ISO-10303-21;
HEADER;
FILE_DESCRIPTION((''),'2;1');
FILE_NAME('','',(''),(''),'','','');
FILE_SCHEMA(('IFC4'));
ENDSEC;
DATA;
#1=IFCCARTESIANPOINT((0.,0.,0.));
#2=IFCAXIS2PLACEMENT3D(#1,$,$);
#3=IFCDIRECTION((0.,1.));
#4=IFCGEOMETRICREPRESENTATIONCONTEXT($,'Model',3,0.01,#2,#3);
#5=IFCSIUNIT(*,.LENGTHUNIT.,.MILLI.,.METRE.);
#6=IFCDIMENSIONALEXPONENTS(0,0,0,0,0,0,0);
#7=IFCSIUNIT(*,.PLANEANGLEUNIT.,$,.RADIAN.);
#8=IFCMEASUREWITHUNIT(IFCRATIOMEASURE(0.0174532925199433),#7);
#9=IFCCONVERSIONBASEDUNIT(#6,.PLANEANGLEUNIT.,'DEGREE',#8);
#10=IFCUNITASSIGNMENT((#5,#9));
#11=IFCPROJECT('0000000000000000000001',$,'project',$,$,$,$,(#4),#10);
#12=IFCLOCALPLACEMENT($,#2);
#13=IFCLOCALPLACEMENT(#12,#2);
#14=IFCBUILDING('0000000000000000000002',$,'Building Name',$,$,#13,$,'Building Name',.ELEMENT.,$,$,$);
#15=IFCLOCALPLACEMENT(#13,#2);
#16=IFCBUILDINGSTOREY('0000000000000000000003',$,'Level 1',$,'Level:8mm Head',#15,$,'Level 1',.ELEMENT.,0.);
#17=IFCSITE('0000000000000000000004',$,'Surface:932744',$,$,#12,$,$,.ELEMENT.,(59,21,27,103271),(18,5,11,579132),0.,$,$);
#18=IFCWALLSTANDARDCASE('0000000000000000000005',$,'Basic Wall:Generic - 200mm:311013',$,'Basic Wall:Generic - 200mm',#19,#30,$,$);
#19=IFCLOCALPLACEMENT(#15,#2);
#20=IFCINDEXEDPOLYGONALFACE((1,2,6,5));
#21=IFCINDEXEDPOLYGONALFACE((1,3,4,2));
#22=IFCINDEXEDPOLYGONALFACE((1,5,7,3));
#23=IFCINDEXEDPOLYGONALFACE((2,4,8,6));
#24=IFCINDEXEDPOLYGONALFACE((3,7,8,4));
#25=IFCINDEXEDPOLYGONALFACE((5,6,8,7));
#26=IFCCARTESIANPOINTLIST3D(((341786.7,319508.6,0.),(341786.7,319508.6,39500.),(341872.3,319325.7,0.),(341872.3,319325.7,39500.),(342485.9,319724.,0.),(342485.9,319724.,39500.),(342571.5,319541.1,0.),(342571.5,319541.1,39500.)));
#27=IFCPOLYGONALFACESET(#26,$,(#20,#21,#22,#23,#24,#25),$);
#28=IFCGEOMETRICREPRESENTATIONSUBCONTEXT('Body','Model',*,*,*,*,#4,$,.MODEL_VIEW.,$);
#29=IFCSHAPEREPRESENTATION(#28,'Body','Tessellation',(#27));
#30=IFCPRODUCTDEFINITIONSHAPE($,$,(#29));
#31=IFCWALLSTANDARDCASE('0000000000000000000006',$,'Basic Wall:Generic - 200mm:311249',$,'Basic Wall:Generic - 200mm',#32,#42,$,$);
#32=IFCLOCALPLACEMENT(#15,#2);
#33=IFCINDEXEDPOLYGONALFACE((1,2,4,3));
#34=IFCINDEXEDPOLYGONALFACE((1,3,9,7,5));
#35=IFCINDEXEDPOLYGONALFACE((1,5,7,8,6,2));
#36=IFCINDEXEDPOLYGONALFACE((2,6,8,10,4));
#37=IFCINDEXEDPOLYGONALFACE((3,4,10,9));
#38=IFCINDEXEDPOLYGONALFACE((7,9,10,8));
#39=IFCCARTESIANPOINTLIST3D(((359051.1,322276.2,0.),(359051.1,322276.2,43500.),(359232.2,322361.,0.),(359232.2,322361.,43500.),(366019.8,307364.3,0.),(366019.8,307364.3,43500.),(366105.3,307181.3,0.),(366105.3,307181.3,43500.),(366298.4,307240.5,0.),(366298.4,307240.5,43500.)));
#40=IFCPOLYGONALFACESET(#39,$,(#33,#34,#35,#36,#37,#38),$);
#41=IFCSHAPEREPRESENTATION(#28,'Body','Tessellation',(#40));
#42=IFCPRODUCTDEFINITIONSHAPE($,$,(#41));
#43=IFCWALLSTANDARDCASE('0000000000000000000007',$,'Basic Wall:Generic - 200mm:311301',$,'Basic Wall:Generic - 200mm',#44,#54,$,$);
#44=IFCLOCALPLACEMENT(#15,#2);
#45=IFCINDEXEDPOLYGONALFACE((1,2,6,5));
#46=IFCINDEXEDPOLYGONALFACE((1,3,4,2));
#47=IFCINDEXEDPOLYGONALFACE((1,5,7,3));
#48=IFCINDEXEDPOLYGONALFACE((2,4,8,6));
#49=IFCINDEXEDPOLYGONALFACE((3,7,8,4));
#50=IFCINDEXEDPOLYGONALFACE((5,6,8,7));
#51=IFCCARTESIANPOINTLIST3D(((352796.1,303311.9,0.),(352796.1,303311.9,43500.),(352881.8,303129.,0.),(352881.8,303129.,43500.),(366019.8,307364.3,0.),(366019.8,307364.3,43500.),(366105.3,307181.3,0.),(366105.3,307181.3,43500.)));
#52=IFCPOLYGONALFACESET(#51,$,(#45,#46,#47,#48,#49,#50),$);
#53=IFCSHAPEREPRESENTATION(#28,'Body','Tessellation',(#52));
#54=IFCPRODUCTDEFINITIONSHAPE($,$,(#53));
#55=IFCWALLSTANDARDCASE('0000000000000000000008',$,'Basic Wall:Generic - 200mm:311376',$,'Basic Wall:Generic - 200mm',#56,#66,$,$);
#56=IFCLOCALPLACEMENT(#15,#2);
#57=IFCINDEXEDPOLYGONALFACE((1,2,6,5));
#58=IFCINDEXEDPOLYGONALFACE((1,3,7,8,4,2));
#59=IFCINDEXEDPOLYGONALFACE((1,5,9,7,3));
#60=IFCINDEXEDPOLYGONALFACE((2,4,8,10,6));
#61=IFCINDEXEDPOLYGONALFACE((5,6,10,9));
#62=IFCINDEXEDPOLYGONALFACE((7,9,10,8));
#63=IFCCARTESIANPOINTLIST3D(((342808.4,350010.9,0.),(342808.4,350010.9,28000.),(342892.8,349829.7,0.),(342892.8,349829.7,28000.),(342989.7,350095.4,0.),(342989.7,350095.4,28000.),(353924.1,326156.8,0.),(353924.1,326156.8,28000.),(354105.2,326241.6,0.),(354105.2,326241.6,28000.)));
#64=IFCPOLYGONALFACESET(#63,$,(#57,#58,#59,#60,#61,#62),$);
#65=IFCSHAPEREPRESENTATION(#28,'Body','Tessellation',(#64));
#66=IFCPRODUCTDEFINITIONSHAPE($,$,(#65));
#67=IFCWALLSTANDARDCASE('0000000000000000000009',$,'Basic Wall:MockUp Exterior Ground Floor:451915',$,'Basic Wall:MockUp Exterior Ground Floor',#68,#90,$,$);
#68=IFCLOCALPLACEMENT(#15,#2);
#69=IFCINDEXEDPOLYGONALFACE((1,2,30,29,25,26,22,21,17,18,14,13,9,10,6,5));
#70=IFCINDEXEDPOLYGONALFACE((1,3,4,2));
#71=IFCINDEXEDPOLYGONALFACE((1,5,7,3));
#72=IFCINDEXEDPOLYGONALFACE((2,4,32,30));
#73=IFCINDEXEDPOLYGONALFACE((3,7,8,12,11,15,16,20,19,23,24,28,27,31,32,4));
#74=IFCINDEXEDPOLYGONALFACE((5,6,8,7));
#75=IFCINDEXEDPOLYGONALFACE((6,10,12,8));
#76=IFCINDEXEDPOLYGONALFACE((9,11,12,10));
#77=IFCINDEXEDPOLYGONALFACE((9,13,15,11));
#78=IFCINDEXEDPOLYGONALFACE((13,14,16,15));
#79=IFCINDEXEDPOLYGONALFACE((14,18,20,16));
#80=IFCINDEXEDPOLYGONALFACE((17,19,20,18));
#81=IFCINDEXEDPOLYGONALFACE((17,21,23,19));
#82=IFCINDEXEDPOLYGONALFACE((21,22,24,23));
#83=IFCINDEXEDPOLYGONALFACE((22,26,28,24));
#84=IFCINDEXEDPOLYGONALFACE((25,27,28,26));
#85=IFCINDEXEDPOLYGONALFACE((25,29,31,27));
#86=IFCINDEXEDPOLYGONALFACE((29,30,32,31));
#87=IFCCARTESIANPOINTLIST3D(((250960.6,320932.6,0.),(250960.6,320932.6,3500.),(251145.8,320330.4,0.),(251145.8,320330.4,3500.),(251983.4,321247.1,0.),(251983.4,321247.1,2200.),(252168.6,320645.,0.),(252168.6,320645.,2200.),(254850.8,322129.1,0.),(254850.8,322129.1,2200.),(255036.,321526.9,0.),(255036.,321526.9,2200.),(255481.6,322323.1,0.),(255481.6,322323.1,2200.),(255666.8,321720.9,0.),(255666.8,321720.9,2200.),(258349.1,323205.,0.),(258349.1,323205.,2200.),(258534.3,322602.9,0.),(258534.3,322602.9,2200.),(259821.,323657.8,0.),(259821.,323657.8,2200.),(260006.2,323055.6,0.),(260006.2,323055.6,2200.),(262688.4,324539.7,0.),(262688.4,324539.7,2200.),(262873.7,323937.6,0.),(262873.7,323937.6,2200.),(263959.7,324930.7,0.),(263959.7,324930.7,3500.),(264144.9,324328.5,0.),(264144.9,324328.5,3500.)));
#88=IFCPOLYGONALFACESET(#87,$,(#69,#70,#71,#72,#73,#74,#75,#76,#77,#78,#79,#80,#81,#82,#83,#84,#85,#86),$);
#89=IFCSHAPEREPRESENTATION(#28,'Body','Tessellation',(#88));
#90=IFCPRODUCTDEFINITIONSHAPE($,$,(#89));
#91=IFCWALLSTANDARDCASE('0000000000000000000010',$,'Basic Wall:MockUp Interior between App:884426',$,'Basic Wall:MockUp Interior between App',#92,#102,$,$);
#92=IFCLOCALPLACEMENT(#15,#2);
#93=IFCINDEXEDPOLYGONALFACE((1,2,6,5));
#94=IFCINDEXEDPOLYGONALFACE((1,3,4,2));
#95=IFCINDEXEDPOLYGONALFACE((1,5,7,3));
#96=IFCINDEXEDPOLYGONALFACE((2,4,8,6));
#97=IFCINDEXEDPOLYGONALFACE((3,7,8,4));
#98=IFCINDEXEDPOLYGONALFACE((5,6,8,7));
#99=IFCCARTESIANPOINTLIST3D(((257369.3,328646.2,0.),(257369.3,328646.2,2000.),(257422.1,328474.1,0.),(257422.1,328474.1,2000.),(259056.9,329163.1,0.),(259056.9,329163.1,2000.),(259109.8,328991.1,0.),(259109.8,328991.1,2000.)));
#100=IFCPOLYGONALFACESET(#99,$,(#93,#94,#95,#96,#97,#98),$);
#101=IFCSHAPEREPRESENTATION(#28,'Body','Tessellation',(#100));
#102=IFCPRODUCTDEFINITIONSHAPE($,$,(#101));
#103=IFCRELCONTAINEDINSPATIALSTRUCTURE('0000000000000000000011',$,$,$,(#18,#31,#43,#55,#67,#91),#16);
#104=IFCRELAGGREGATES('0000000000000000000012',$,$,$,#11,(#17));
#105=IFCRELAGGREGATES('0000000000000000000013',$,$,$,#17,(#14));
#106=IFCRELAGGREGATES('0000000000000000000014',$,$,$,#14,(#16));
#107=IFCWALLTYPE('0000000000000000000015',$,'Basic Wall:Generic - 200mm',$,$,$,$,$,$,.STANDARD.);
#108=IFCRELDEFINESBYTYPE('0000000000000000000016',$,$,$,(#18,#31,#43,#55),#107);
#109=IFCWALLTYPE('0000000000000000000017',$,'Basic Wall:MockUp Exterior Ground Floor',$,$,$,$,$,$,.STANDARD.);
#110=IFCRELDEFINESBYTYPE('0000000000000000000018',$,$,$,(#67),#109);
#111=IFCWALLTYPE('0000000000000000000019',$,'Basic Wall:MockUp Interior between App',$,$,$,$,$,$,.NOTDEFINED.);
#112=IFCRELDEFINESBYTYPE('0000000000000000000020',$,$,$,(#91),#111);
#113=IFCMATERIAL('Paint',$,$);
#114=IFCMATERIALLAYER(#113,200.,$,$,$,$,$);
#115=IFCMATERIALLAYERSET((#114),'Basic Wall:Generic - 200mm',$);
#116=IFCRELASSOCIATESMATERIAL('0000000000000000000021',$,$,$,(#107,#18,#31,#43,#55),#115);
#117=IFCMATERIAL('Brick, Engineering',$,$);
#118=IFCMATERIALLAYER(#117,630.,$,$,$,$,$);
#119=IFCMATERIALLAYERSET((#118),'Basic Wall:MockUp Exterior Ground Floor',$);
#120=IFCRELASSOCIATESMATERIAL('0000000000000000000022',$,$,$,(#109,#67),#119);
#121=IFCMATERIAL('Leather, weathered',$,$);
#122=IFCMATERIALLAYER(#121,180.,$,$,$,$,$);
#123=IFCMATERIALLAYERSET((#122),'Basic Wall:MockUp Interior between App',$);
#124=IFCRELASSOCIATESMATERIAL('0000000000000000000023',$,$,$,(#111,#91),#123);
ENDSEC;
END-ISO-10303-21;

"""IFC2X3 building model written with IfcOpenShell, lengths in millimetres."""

from ifc_helpers import new_model, entity, si_unit, converted_unit, direction, frame, frame_2d, origin, place, context, subcontext, project, spatial, polyline, rectangle, outline, extrude, material, layer, layer_set, layer_usage, type_object, element, save


model = new_model("IFC2X3")

# Units and contexts
model_context = context("Model", 3, precision=0.01, world=origin(), true_north=direction((0.0, 1.0)))
body_context = subcontext(model_context, "Body", "Model", "MODEL_VIEW")
ifc_project = project(units=[si_unit("LENGTHUNIT", "METRE", prefix="MILLI"), converted_unit("PLANEANGLEUNIT", "DEGREE", entity("IfcRatioMeasure", 0.0174532925199433), si_unit("PLANEANGLEUNIT", "RADIAN"), dimensions=[0, 0, 0, 0, 0, 0, 0])], contexts=[model_context])

# Site, building, storey
site_placement = place(None, origin())
site = spatial("IfcSite", under=ifc_project, at=site_placement, Name="Surface:932744", CompositionType="ELEMENT", RefLatitude=(59, 21, 27, 103271), RefLongitude=(18, 5, 11, 579132), RefElevation=0.0)
building_placement = place(site_placement, origin())
building = spatial("IfcBuilding", under=site, at=building_placement, Name="Building Name", LongName="Building Name", CompositionType="ELEMENT")
storey_placement = place(building_placement, origin())
storey = spatial("IfcBuildingStorey", under=building, at=storey_placement, Name="Level 1", ObjectType="Level:8mm Head", LongName="Level 1", CompositionType="ELEMENT", Elevation=0.0)

# Shared definitions
ifc_material_1 = material(Name="Paint")
ifc_layer_1 = layer(ifc_material_1, 200.0)
ifc_layer_set_1 = layer_set([ifc_layer_1], Name="Basic Wall:Generic - 200mm")
wall_type_1 = type_object("IfcWallType", Name="Basic Wall:Generic - 200mm", PredefinedType="STANDARD", material=ifc_layer_set_1)

# Walls
ifc_layer_usage_1 = layer_usage(ifc_layer_set_1, "AXIS2", "NEGATIVE", 100.0)
wall_1_placement = place(storey_placement, frame((342542.1, 319636.6, 0.0), z_axis=(0.0, 0.0, 1.0), x_axis=(-0.955682, -0.294402, 0.0)))
element("IfcWallStandardCase", 1, at=wall_1_placement, inside=storey, type_object=wall_type_1, material=ifc_layer_usage_1, Name="Basic Wall:Generic - 200mm:311013", ObjectType="Basic Wall:Generic - 200mm", context=body_context, shape_type="SweptSolid", body=[
    extrude(outline(polyline([(759.6, -100.0), (731.6, 100.0), (0.0, 100.0), (28.0, -100.0), (759.6, -100.0)])), origin(), (0.0, 0.0, 1.0), 39500.0),
])
ifc_layer_usage_2 = layer_usage(ifc_layer_set_1, "AXIS2", "NEGATIVE", 100.0)
wall_2_placement = place(storey_placement, frame((359141.6, 322318.7, 0.0), z_axis=(0.0, 0.0, 1.0), x_axis=(0.423376, -0.905954, 0.0)))
element("IfcWallStandardCase", 2, at=wall_2_placement, inside=storey, type_object=wall_type_1, material=ifc_layer_usage_2, Name="Basic Wall:Generic - 200mm:311249", ObjectType="Basic Wall:Generic - 200mm", context=body_context, shape_type="SweptSolid", body=[
    extrude(outline(polyline([(16662.0, -100.0), (16690.2, 100.0), (0.0, 100.0), (0.2, -100.0), (16460.1, -100.0), (16662.0, -100.0)])), origin(), (0.0, 0.0, 1.0), 43500.0),
])
ifc_layer_usage_3 = layer_usage(ifc_layer_set_1, "AXIS2", "NEGATIVE", 100.0)
wall_3_placement = place(storey_placement, frame((366076.0, 307276.9, 0.0), z_axis=(0.0, 0.0, 1.0), x_axis=(-0.956113, -0.292999, 0.0)))
element("IfcWallStandardCase", 3, at=wall_3_placement, inside=storey, type_object=wall_type_1, material=ifc_layer_usage_3, Name="Basic Wall:Generic - 200mm:311301", ObjectType="Basic Wall:Generic - 200mm", context=body_context, shape_type="SweptSolid", body=[
    extrude(outline(polyline([(13858.8, -100.0), (13830.5, 100.0), (0.0, 100.0), (28.1, -100.0), (13858.8, -100.0)])), origin(), (0.0, 0.0, 1.0), 43500.0),
])
ifc_layer_usage_4 = layer_usage(ifc_layer_set_1, "AXIS2", "NEGATIVE", 100.0)
wall_4_placement = place(storey_placement, frame((354014.8, 326199.0, 0.0), z_axis=(0.0, 0.0, 1.0), x_axis=(-0.42238, 0.906419, 0.0)))
element("IfcWallStandardCase", 4, at=wall_4_placement, inside=storey, type_object=wall_type_1, material=ifc_layer_usage_4, Name="Basic Wall:Generic - 200mm:311376", ObjectType="Basic Wall:Generic - 200mm", context=body_context, shape_type="SweptSolid", body=[
    extrude(outline(polyline([(26317.0, -100.0), (26317.0, 100.0), (26117.0, 100.0), (0.0, 100.0), (0.4, -100.0), (26317.0, -100.0)])), origin(), (0.0, 0.0, 1.0), 28000.0),
])

# Wall, openings
ifc_material_2 = material(Name="Brick, Engineering")
ifc_layer_2 = layer(ifc_material_2, 630.0)
ifc_layer_set_2 = layer_set([ifc_layer_2], Name="Basic Wall:MockUp Exterior Ground Floor")
ifc_layer_usage_5 = layer_usage(ifc_layer_set_2, "AXIS2", "POSITIVE", -315.0)
wall_type_2 = type_object("IfcWallType", Name="Basic Wall:MockUp Exterior Ground Floor", PredefinedType="STANDARD", material=ifc_layer_set_2)
wall_5_placement = place(storey_placement, frame((264052.3, 324629.6, 0.0), z_axis=(0.0, 0.0, 1.0), x_axis=(-0.955811, -0.29398, 0.0)))
wall_5 = element("IfcWallStandardCase", 5, at=wall_5_placement, inside=storey, type_object=wall_type_2, material=ifc_layer_usage_5, Name="Basic Wall:MockUp Exterior Ground Floor:451915", ObjectType="Basic Wall:MockUp Exterior Ground Floor", context=body_context, shape_type="SweptSolid", body=[
    extrude(rectangle(XDim=13600.0, YDim=630.0, at=frame_2d((6800.0, 0.0), x_axis=(-1.0, 0.0))), origin(), (0.0, 0.0, 1.0), 3500.0),
])
opening_1_placement = place(wall_5_placement, frame((12530.0, 315.0, 0.0)))
element("IfcOpeningElement", 6, at=opening_1_placement, cuts=wall_5, ObjectType="Opening", context=body_context, shape_type="SweptSolid", body=[
    extrude(rectangle(XDim=2200.0, YDim=3000.0, at=frame_2d((1100.0, 1500.0), x_axis=(1.0, 0.0))), frame((0.0, 0.0, 0.0), z_axis=(0.0, -1.0, 0.0), x_axis=(0.0, 0.0, 1.0)), (0.0, 0.0, 1.0), 630.0),
])
opening_2_placement = place(wall_5_placement, frame((8870.0, 315.0, 0.0)))
element("IfcOpeningElement", 7, at=opening_2_placement, cuts=wall_5, ObjectType="Opening", context=body_context, shape_type="SweptSolid", body=[
    extrude(rectangle(XDim=2200.0, YDim=3000.0, at=frame_2d((1100.0, 1500.0), x_axis=(1.0, 0.0))), frame((0.0, 0.0, 0.0), z_axis=(0.0, -1.0, 0.0), x_axis=(0.0, 0.0, 1.0)), (0.0, 0.0, 1.0), 630.0),
])
opening_3_placement = place(wall_5_placement, frame((4330.0, 315.0, 0.0)))
element("IfcOpeningElement", 8, at=opening_3_placement, cuts=wall_5, ObjectType="Opening", context=body_context, shape_type="SweptSolid", body=[
    extrude(rectangle(XDim=2200.0, YDim=3000.0, at=frame_2d((1100.0, 1500.0), x_axis=(1.0, 0.0))), frame((0.0, 0.0, 0.0), z_axis=(0.0, -1.0, 0.0), x_axis=(0.0, 0.0, 1.0)), (0.0, 0.0, 1.0), 630.0),
])

# Wall
ifc_material_3 = material(Name="Leather, weathered")
ifc_layer_3 = layer(ifc_material_3, 180.0)
ifc_layer_set_3 = layer_set([ifc_layer_3], Name="Basic Wall:MockUp Interior between App")
ifc_layer_usage_6 = layer_usage(ifc_layer_set_3, "AXIS2", "NEGATIVE", 90.0)
wall_type_3 = type_object("IfcWallType", Name="Basic Wall:MockUp Interior between App", PredefinedType="NOTDEFINED", material=ifc_layer_set_3)
wall_6_placement = place(building_placement, frame((259083.4, 329077.1, 0.0), z_axis=(0.0, 0.0, 1.0), x_axis=(-0.956149, -0.29288, 0.0)))
element("IfcWallStandardCase", 9, at=wall_6_placement, inside=storey, type_object=wall_type_3, material=ifc_layer_usage_6, Name="Basic Wall:MockUp Interior between App:884426", ObjectType="Basic Wall:MockUp Interior between App", context=body_context, shape_type="SweptSolid", body=[
    extrude(outline(polyline([(1765.1, -90.0), (1765.1, 90.0), (0.0, 90.0), (0.2, -90.0), (1765.1, -90.0)])), origin(), (0.0, 0.0, 1.0), 2000.0),
])

save(model, "model.ifc")
